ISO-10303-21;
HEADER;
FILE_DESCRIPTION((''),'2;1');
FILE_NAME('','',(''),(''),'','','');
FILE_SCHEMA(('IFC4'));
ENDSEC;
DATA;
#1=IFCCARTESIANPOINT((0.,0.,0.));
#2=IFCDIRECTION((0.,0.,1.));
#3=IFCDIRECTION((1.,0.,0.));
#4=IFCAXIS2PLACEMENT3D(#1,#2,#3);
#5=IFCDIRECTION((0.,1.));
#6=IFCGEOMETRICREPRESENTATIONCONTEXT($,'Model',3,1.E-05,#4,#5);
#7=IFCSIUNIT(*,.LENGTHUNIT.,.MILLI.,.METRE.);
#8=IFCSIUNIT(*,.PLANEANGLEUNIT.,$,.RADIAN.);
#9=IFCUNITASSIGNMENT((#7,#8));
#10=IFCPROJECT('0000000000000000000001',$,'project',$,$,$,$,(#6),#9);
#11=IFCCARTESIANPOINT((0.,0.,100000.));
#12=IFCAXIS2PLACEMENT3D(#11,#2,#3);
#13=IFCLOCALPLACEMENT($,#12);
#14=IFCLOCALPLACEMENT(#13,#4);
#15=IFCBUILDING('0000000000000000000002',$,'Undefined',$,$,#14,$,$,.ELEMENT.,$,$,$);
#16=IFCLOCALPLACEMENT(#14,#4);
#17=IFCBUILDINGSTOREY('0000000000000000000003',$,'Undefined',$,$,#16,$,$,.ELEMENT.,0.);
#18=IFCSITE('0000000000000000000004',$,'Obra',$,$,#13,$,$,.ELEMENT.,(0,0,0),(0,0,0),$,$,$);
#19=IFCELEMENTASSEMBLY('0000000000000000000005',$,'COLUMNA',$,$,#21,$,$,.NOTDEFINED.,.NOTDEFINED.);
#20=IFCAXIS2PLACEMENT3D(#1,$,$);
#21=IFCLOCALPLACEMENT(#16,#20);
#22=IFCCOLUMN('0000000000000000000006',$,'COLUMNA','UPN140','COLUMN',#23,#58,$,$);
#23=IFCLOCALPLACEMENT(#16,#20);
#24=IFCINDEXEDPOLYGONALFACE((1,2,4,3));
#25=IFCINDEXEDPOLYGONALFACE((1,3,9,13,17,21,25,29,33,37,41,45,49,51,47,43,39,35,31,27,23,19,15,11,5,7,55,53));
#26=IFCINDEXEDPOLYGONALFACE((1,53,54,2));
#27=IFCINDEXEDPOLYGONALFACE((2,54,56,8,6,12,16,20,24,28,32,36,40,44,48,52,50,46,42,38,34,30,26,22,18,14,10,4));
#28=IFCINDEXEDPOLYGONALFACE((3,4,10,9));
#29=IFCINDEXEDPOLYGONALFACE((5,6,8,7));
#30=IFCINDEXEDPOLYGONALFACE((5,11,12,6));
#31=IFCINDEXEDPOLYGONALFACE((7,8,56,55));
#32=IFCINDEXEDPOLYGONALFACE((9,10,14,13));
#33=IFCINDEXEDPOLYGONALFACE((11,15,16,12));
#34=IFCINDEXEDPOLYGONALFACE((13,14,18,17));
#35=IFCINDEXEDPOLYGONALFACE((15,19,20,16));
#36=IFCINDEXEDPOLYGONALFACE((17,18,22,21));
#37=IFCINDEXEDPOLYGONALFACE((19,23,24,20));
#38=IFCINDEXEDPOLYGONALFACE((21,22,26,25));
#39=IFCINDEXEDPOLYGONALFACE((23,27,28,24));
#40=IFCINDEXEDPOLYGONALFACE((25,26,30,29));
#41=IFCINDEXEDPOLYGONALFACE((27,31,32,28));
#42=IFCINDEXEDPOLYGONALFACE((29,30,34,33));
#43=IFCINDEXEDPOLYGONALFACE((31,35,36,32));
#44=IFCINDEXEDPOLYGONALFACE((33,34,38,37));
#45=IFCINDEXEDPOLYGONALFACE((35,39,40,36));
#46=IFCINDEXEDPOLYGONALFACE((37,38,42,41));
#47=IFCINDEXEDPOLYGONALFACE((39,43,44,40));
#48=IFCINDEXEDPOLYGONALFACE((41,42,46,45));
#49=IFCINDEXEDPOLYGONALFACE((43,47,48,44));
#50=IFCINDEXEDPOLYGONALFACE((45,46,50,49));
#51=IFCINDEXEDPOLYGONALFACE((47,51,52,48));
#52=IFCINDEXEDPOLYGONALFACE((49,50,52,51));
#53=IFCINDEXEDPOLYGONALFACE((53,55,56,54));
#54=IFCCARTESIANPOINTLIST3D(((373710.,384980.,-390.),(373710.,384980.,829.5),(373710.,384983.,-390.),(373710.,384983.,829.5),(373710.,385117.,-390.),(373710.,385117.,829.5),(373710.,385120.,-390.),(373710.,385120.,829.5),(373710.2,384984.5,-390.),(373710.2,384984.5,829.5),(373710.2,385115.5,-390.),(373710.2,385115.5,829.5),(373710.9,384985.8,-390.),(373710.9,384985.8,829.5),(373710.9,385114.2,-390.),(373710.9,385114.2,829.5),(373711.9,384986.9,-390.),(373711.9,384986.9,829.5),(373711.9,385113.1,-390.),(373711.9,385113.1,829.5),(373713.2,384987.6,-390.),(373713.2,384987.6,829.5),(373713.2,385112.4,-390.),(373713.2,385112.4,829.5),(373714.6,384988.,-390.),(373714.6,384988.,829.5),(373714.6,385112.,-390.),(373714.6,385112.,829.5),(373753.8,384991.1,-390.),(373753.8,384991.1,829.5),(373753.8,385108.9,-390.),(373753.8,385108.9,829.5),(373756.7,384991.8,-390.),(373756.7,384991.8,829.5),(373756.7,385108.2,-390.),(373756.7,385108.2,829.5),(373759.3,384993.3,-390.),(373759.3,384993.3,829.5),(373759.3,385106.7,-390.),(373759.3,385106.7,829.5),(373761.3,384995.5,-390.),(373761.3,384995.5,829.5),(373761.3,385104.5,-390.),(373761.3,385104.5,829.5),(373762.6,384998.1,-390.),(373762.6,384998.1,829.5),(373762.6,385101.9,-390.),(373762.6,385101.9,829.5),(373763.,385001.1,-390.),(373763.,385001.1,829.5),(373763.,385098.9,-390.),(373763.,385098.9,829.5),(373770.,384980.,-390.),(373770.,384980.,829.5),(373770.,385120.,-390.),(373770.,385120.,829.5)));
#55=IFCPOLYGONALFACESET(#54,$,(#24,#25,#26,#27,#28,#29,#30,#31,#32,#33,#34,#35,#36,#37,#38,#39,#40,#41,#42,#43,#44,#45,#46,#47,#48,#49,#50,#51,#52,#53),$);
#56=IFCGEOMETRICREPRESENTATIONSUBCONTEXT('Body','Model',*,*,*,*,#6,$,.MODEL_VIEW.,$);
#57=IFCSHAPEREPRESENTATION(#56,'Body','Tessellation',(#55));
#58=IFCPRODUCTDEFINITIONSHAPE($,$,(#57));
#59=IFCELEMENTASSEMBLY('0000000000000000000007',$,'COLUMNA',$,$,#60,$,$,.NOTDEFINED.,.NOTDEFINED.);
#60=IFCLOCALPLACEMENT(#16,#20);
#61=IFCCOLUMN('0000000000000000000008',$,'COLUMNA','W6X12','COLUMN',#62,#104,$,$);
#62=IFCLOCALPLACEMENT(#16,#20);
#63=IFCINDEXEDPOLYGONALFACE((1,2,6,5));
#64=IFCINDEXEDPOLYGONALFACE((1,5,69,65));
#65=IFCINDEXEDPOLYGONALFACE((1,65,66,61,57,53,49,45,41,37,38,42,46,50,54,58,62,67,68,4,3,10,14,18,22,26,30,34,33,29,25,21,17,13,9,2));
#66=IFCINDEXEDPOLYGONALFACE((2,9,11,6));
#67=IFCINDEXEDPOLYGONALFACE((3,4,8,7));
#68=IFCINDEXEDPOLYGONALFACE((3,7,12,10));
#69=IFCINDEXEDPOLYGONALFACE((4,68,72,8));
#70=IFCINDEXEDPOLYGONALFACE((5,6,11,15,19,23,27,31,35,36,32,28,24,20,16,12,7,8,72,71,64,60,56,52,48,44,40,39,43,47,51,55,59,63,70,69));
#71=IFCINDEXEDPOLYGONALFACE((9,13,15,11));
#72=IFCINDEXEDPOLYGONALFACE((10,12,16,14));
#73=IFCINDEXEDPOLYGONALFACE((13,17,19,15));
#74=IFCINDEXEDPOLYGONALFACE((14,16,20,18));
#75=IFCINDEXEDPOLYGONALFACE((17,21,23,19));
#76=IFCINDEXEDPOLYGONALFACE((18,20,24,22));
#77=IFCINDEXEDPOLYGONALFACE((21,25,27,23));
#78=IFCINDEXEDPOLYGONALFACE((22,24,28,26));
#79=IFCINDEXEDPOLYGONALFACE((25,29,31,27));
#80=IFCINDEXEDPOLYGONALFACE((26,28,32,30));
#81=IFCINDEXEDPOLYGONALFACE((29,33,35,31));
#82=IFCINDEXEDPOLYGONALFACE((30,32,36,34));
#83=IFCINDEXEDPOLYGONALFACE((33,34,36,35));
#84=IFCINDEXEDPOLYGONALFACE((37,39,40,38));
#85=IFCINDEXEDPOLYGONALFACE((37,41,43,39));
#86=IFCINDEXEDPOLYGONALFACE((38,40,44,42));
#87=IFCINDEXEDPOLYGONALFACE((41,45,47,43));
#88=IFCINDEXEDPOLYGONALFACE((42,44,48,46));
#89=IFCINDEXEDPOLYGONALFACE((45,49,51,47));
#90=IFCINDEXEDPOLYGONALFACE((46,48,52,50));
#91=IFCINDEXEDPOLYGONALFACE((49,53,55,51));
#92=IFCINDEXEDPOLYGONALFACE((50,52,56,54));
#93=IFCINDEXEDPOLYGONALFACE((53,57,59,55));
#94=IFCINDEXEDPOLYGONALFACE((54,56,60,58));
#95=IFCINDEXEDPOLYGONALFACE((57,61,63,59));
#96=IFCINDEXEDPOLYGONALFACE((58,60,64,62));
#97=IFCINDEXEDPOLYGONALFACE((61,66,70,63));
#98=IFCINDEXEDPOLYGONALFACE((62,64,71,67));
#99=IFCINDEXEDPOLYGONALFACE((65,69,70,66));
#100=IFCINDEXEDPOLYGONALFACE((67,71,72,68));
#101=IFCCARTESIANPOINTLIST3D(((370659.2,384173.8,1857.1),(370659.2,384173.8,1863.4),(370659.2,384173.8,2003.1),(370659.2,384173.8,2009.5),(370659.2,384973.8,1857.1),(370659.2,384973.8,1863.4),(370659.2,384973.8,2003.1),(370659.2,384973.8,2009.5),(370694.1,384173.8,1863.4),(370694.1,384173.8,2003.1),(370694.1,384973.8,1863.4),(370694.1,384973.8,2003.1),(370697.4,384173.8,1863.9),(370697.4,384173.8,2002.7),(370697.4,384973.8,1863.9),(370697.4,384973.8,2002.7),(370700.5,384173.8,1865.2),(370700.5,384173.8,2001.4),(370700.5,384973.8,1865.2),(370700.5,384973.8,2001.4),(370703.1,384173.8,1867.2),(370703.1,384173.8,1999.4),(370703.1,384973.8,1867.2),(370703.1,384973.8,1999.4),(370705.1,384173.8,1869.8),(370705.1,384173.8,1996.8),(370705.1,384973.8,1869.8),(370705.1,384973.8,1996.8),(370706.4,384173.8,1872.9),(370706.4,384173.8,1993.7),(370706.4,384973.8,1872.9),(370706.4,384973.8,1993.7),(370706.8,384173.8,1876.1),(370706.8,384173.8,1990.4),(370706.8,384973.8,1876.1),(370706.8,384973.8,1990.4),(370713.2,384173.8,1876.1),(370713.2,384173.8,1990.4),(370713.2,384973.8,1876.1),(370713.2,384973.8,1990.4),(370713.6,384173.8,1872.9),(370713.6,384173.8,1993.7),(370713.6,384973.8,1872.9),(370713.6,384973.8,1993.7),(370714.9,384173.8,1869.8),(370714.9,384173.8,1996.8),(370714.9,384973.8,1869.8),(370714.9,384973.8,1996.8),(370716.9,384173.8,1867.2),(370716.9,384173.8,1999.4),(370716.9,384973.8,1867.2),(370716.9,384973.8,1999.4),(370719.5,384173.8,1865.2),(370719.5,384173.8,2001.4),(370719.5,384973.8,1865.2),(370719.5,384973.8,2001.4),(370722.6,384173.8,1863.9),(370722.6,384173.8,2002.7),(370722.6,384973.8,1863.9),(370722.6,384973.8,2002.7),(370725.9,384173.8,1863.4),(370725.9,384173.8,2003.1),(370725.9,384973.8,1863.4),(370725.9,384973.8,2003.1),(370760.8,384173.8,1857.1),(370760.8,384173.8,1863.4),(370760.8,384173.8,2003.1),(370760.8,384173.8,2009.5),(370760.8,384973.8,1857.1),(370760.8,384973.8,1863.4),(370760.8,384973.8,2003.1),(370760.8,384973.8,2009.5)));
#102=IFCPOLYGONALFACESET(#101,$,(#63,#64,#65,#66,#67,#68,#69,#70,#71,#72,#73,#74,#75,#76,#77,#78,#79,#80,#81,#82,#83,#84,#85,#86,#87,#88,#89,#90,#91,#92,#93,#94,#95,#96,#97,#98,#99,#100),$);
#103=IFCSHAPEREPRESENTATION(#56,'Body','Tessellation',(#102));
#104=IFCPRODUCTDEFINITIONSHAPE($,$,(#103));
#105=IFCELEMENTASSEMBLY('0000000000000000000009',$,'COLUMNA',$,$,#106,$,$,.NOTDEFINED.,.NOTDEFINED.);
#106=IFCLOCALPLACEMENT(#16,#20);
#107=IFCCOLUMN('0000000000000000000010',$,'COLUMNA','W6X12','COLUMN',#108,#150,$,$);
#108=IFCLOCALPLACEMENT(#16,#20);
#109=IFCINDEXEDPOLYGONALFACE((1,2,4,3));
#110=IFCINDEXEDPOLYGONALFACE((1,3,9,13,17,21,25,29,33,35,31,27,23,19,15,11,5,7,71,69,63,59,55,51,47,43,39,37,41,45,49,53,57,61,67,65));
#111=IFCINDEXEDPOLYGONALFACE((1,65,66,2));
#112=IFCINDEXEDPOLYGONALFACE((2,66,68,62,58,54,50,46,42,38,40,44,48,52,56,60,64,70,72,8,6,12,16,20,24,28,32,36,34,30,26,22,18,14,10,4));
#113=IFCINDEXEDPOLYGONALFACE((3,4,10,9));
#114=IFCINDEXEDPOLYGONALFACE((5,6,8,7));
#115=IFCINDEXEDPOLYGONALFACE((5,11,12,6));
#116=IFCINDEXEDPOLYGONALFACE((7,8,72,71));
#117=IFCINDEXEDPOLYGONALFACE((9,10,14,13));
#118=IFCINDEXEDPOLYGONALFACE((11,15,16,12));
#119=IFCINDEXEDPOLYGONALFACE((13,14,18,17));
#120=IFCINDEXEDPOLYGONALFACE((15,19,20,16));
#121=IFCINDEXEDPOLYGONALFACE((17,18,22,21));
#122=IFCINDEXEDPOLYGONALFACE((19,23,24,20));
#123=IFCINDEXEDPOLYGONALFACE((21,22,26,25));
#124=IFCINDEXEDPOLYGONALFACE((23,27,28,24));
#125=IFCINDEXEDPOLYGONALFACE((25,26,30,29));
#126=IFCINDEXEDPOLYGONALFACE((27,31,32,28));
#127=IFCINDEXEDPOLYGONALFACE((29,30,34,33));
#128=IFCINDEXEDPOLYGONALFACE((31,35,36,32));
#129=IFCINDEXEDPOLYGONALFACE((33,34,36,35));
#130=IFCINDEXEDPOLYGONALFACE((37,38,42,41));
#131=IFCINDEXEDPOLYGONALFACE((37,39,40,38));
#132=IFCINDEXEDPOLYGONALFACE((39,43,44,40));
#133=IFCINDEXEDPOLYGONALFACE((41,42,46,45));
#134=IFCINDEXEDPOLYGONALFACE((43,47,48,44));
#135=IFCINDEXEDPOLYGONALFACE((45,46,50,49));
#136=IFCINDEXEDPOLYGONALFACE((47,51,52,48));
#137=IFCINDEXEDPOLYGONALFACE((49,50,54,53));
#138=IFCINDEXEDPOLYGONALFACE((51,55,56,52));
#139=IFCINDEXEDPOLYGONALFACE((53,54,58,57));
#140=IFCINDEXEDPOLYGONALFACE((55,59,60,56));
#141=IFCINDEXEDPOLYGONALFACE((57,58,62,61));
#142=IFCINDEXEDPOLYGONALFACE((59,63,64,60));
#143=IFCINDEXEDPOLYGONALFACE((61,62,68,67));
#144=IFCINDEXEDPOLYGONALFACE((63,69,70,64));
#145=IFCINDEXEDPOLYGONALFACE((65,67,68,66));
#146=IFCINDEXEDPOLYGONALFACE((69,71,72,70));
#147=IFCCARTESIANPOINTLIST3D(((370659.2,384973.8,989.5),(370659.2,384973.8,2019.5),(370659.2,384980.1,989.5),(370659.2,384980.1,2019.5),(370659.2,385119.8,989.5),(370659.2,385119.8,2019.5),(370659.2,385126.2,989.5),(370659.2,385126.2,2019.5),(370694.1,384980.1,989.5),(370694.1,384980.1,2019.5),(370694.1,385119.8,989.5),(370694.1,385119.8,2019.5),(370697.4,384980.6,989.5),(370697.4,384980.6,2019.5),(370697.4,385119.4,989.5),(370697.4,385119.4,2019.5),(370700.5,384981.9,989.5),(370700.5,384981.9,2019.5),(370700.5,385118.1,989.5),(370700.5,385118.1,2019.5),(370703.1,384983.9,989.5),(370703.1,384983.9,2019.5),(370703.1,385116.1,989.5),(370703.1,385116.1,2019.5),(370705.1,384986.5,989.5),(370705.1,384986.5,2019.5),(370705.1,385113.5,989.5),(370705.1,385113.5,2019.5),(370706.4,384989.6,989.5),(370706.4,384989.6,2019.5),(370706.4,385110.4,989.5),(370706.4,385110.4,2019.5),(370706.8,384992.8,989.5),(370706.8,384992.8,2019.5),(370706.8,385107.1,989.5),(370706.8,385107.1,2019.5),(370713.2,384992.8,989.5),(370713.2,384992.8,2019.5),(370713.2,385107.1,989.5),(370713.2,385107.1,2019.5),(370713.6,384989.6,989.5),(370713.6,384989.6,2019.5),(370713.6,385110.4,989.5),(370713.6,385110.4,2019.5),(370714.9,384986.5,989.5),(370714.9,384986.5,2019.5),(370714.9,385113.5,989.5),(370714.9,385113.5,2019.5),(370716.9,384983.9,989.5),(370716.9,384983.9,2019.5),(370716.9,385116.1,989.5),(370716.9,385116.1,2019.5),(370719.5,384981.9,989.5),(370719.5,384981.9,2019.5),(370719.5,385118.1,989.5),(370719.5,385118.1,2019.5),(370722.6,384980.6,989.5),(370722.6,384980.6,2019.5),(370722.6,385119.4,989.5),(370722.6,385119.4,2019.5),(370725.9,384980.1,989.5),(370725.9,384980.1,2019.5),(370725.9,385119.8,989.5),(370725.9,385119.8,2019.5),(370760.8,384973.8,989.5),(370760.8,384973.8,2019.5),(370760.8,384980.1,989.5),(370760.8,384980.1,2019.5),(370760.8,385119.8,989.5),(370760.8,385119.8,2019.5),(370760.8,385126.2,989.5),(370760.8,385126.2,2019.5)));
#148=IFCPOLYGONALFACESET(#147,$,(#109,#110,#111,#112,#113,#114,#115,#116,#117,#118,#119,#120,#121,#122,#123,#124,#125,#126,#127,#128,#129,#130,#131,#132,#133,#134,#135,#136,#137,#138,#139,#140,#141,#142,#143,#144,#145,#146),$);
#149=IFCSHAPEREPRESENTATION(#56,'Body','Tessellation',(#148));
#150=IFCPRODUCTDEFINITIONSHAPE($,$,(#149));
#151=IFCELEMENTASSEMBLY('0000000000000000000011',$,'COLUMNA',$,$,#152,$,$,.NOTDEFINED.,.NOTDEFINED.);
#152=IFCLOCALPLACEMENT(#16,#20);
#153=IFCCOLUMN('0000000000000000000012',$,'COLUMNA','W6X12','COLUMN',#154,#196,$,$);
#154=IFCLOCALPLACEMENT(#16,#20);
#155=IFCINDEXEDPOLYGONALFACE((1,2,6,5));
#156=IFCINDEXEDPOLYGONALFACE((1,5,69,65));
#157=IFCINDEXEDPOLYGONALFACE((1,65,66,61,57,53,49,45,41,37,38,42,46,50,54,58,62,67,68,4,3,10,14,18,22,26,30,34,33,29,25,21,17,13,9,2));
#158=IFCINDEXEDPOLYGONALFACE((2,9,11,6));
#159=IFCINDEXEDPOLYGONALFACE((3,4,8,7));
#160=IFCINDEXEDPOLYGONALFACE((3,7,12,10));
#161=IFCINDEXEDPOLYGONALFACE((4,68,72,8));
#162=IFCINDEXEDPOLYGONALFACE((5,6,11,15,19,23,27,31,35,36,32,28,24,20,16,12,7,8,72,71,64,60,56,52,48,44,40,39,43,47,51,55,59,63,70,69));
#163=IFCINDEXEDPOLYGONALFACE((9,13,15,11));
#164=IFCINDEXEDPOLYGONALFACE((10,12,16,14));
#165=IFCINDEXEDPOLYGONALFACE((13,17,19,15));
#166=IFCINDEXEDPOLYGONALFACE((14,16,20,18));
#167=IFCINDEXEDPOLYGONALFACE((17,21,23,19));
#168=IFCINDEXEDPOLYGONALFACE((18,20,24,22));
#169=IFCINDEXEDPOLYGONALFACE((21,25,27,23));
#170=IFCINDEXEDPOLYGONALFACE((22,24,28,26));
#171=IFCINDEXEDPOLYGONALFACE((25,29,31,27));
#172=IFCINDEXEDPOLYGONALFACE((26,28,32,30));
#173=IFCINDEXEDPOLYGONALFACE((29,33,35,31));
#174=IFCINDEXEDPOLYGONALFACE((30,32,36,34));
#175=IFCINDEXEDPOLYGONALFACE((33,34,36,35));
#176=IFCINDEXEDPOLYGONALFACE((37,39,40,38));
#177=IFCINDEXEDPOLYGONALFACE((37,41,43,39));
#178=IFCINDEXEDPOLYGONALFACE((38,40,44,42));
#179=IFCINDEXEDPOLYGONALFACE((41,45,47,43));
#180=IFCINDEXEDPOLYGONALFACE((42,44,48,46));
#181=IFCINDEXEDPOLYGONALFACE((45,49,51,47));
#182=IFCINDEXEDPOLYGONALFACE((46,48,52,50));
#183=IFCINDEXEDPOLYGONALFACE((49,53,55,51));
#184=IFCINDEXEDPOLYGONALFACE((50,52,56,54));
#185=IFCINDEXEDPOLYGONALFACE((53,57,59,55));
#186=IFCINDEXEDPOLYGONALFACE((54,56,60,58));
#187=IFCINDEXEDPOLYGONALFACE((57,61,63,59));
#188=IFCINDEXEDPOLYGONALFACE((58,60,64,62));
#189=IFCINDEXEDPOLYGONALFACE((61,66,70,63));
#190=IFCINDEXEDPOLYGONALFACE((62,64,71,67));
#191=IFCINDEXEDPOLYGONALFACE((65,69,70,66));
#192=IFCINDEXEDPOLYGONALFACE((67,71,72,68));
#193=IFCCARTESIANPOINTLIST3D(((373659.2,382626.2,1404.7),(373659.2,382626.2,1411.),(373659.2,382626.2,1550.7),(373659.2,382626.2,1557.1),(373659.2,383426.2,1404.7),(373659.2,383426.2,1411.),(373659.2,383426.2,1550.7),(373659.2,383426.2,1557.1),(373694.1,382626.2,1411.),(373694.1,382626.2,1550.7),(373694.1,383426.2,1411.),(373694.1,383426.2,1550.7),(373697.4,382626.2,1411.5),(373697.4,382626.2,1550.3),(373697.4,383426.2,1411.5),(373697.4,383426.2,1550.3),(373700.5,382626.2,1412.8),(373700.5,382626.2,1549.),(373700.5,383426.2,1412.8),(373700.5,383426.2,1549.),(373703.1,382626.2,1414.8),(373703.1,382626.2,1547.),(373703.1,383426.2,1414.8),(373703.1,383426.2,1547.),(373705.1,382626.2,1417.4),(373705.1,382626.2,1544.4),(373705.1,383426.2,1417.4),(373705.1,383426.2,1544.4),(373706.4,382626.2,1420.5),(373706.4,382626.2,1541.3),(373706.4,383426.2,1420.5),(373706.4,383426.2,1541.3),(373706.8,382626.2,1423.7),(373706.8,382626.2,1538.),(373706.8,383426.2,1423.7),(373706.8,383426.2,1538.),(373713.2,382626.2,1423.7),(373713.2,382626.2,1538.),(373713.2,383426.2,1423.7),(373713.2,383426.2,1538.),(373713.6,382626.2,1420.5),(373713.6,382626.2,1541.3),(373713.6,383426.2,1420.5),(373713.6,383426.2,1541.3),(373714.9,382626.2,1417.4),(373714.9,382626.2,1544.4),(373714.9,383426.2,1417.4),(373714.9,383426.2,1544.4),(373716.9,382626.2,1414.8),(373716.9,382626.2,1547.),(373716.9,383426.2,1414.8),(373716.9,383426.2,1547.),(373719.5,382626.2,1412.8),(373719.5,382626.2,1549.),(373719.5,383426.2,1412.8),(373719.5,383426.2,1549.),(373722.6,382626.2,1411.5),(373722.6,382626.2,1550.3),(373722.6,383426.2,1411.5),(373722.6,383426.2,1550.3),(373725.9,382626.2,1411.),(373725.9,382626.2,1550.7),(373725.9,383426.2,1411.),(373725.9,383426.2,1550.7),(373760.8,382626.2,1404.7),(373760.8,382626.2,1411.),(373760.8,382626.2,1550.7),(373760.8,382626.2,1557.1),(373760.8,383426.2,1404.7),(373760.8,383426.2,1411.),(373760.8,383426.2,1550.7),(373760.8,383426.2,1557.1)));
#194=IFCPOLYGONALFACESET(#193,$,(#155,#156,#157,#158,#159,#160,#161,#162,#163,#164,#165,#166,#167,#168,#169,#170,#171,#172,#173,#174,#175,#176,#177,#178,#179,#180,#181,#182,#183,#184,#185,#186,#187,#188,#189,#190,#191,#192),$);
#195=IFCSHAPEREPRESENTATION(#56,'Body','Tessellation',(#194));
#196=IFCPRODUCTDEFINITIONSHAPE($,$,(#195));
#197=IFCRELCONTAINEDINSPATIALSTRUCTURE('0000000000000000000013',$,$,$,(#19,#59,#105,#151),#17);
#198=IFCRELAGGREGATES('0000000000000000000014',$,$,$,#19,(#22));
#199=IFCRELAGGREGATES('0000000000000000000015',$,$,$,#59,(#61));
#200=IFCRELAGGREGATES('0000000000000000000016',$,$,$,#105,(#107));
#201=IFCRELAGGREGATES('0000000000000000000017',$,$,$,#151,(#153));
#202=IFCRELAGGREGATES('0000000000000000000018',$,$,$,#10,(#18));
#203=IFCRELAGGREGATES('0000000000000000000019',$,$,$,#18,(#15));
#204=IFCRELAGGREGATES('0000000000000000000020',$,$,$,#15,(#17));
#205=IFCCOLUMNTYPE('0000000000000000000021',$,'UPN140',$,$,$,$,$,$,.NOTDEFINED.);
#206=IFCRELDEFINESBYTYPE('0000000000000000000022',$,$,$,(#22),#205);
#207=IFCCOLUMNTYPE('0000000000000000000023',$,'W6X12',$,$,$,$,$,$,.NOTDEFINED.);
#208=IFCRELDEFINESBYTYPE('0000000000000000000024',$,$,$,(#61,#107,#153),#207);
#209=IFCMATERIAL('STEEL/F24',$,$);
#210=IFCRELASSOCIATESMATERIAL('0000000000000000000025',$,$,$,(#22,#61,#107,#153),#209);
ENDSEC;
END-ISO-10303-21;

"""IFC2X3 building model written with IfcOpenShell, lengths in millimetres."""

from ifc_helpers import new_model, si_unit, direction, frame, origin_with_axes, origin_2d_with_axis, place, context, subcontext, project, spatial, i_section, u_section, extrude, material, type_object, element, aggregate, save


model = new_model("IFC2X3")

# Units and contexts
model_context = context("Model", 3, precision=1e-05, world=origin_with_axes(), true_north=direction((0.0, 1.0)))
body_context = subcontext(model_context, "Body", "Model", "MODEL_VIEW")
ifc_project = project(units=[si_unit("LENGTHUNIT", "METRE", prefix="MILLI"), si_unit("PLANEANGLEUNIT", "RADIAN")], contexts=[model_context])

# Site, building, storey
site_placement = place(None, frame((0.0, 0.0, 100000.0), z_axis=(0.0, 0.0, 1.0), x_axis=(1.0, 0.0, 0.0)))
site = spatial("IfcSite", under=ifc_project, at=site_placement, Name="Obra", CompositionType="ELEMENT", RefLatitude=(0, 0, 0), RefLongitude=(0, 0, 0))
building_placement = place(site_placement, origin_with_axes())
building = spatial("IfcBuilding", under=site, at=building_placement, Name="Undefined", CompositionType="ELEMENT")
storey_placement = place(building_placement, origin_with_axes())
storey = spatial("IfcBuildingStorey", under=building, at=storey_placement, Name="Undefined", CompositionType="ELEMENT", Elevation=0.0)

# Element assemblies, columns
ifc_material_1 = material(Name="STEEL/F24")
column_type_1 = type_object("IfcColumnType", Name="UPN140", PredefinedType="NOTDEFINED")
assembly_1_placement = place(storey_placement, origin_with_axes())
assembly_1 = element("IfcElementAssembly", 1, at=assembly_1_placement, inside=storey, Name="COLUMNA", AssemblyPlace="NOTDEFINED", PredefinedType="NOTDEFINED")
column_1_placement = place(assembly_1_placement, frame((373740.0, 385050.0, -390.0), z_axis=(0.0, 0.0, 1.0), x_axis=(0.0, 1.0, 0.0)))
column_1 = element("IfcColumn", 2, at=column_1_placement, type_object=column_type_1, material=ifc_material_1, Name="COLUMNA", Description="UPN140", ObjectType="COLUMN", context=body_context, shape_type="SweptSolid", body=[
    extrude(u_section(Depth=140.0, FlangeWidth=60.0, WebThickness=7.0, FlangeThickness=10.0, FilletRadius=10.0, EdgeRadius=5.0, FlangeSlope=0.07983, at=origin_2d_with_axis()), frame((0.0, 0.0, 1219.5), z_axis=(0.0, 0.0, -1.0), x_axis=(0.0, 1.0, 0.0)), (0.0, 0.0, 1.0), 1219.5),
])
aggregate(assembly_1, [column_1])
assembly_2_placement = place(storey_placement, origin_with_axes())
assembly_2 = element("IfcElementAssembly", 3, at=assembly_2_placement, inside=storey, Name="COLUMNA", AssemblyPlace="NOTDEFINED", PredefinedType="NOTDEFINED")
column_type_2 = type_object("IfcColumnType", Name="W6X12", PredefinedType="NOTDEFINED")
column_2_placement = place(assembly_2_placement, frame((370710.0, 384973.8, 1933.3), z_axis=(0.0, -1.0, 0.0), x_axis=(0.0, 0.0, -1.0)))
column_2 = element("IfcColumn", 4, at=column_2_placement, type_object=column_type_2, material=ifc_material_1, Name="COLUMNA", Description="W6X12", ObjectType="COLUMN", context=body_context, shape_type="SweptSolid", body=[
    extrude(i_section(OverallWidth=101.6, OverallDepth=152.4, WebThickness=6.3, FlangeThickness=6.3, FilletRadius=12.7, at=origin_2d_with_axis()), frame((0.0, 0.0, 800.0), z_axis=(0.0, 0.0, -1.0), x_axis=(0.0, 1.0, 0.0)), (0.0, 0.0, 1.0), 800.0),
])
aggregate(assembly_2, [column_2])
assembly_3_placement = place(storey_placement, origin_with_axes())
assembly_3 = element("IfcElementAssembly", 5, at=assembly_3_placement, inside=storey, Name="COLUMNA", AssemblyPlace="NOTDEFINED", PredefinedType="NOTDEFINED")
column_3_placement = place(assembly_3_placement, frame((370710.0, 385050.0, 989.5), z_axis=(0.0, 0.0, 1.0), x_axis=(0.0, 1.0, 0.0)))
column_3 = element("IfcColumn", 6, at=column_3_placement, type_object=column_type_2, material=ifc_material_1, Name="COLUMNA", Description="W6X12", ObjectType="COLUMN", context=body_context, shape_type="SweptSolid", body=[
    extrude(i_section(OverallWidth=101.6, OverallDepth=152.4, WebThickness=6.3, FlangeThickness=6.3, FilletRadius=12.7, at=origin_2d_with_axis()), frame((0.0, 0.0, 1030.0), z_axis=(0.0, 0.0, -1.0), x_axis=(0.0, 1.0, 0.0)), (0.0, 0.0, 1.0), 1030.0),
])
aggregate(assembly_3, [column_3])
assembly_4_placement = place(storey_placement, origin_with_axes())
assembly_4 = element("IfcElementAssembly", 7, at=assembly_4_placement, inside=storey, Name="COLUMNA", AssemblyPlace="NOTDEFINED", PredefinedType="NOTDEFINED")
column_4_placement = place(assembly_4_placement, frame((373710.0, 382626.2, 1480.9), z_axis=(0.0, 1.0, 0.0), x_axis=(0.0, 0.0, -1.0)))
column_4 = element("IfcColumn", 8, at=column_4_placement, type_object=column_type_2, material=ifc_material_1, Name="COLUMNA", Description="W6X12", ObjectType="COLUMN", context=body_context, shape_type="SweptSolid", body=[
    extrude(i_section(OverallWidth=101.6, OverallDepth=152.4, WebThickness=6.3, FlangeThickness=6.3, FilletRadius=12.7, at=origin_2d_with_axis()), frame((0.0, 0.0, 800.0), z_axis=(0.0, 0.0, -1.0), x_axis=(0.0, 1.0, 0.0)), (0.0, 0.0, 1.0), 800.0),
])
aggregate(assembly_4, [column_4])

save(model, "model.ifc")
